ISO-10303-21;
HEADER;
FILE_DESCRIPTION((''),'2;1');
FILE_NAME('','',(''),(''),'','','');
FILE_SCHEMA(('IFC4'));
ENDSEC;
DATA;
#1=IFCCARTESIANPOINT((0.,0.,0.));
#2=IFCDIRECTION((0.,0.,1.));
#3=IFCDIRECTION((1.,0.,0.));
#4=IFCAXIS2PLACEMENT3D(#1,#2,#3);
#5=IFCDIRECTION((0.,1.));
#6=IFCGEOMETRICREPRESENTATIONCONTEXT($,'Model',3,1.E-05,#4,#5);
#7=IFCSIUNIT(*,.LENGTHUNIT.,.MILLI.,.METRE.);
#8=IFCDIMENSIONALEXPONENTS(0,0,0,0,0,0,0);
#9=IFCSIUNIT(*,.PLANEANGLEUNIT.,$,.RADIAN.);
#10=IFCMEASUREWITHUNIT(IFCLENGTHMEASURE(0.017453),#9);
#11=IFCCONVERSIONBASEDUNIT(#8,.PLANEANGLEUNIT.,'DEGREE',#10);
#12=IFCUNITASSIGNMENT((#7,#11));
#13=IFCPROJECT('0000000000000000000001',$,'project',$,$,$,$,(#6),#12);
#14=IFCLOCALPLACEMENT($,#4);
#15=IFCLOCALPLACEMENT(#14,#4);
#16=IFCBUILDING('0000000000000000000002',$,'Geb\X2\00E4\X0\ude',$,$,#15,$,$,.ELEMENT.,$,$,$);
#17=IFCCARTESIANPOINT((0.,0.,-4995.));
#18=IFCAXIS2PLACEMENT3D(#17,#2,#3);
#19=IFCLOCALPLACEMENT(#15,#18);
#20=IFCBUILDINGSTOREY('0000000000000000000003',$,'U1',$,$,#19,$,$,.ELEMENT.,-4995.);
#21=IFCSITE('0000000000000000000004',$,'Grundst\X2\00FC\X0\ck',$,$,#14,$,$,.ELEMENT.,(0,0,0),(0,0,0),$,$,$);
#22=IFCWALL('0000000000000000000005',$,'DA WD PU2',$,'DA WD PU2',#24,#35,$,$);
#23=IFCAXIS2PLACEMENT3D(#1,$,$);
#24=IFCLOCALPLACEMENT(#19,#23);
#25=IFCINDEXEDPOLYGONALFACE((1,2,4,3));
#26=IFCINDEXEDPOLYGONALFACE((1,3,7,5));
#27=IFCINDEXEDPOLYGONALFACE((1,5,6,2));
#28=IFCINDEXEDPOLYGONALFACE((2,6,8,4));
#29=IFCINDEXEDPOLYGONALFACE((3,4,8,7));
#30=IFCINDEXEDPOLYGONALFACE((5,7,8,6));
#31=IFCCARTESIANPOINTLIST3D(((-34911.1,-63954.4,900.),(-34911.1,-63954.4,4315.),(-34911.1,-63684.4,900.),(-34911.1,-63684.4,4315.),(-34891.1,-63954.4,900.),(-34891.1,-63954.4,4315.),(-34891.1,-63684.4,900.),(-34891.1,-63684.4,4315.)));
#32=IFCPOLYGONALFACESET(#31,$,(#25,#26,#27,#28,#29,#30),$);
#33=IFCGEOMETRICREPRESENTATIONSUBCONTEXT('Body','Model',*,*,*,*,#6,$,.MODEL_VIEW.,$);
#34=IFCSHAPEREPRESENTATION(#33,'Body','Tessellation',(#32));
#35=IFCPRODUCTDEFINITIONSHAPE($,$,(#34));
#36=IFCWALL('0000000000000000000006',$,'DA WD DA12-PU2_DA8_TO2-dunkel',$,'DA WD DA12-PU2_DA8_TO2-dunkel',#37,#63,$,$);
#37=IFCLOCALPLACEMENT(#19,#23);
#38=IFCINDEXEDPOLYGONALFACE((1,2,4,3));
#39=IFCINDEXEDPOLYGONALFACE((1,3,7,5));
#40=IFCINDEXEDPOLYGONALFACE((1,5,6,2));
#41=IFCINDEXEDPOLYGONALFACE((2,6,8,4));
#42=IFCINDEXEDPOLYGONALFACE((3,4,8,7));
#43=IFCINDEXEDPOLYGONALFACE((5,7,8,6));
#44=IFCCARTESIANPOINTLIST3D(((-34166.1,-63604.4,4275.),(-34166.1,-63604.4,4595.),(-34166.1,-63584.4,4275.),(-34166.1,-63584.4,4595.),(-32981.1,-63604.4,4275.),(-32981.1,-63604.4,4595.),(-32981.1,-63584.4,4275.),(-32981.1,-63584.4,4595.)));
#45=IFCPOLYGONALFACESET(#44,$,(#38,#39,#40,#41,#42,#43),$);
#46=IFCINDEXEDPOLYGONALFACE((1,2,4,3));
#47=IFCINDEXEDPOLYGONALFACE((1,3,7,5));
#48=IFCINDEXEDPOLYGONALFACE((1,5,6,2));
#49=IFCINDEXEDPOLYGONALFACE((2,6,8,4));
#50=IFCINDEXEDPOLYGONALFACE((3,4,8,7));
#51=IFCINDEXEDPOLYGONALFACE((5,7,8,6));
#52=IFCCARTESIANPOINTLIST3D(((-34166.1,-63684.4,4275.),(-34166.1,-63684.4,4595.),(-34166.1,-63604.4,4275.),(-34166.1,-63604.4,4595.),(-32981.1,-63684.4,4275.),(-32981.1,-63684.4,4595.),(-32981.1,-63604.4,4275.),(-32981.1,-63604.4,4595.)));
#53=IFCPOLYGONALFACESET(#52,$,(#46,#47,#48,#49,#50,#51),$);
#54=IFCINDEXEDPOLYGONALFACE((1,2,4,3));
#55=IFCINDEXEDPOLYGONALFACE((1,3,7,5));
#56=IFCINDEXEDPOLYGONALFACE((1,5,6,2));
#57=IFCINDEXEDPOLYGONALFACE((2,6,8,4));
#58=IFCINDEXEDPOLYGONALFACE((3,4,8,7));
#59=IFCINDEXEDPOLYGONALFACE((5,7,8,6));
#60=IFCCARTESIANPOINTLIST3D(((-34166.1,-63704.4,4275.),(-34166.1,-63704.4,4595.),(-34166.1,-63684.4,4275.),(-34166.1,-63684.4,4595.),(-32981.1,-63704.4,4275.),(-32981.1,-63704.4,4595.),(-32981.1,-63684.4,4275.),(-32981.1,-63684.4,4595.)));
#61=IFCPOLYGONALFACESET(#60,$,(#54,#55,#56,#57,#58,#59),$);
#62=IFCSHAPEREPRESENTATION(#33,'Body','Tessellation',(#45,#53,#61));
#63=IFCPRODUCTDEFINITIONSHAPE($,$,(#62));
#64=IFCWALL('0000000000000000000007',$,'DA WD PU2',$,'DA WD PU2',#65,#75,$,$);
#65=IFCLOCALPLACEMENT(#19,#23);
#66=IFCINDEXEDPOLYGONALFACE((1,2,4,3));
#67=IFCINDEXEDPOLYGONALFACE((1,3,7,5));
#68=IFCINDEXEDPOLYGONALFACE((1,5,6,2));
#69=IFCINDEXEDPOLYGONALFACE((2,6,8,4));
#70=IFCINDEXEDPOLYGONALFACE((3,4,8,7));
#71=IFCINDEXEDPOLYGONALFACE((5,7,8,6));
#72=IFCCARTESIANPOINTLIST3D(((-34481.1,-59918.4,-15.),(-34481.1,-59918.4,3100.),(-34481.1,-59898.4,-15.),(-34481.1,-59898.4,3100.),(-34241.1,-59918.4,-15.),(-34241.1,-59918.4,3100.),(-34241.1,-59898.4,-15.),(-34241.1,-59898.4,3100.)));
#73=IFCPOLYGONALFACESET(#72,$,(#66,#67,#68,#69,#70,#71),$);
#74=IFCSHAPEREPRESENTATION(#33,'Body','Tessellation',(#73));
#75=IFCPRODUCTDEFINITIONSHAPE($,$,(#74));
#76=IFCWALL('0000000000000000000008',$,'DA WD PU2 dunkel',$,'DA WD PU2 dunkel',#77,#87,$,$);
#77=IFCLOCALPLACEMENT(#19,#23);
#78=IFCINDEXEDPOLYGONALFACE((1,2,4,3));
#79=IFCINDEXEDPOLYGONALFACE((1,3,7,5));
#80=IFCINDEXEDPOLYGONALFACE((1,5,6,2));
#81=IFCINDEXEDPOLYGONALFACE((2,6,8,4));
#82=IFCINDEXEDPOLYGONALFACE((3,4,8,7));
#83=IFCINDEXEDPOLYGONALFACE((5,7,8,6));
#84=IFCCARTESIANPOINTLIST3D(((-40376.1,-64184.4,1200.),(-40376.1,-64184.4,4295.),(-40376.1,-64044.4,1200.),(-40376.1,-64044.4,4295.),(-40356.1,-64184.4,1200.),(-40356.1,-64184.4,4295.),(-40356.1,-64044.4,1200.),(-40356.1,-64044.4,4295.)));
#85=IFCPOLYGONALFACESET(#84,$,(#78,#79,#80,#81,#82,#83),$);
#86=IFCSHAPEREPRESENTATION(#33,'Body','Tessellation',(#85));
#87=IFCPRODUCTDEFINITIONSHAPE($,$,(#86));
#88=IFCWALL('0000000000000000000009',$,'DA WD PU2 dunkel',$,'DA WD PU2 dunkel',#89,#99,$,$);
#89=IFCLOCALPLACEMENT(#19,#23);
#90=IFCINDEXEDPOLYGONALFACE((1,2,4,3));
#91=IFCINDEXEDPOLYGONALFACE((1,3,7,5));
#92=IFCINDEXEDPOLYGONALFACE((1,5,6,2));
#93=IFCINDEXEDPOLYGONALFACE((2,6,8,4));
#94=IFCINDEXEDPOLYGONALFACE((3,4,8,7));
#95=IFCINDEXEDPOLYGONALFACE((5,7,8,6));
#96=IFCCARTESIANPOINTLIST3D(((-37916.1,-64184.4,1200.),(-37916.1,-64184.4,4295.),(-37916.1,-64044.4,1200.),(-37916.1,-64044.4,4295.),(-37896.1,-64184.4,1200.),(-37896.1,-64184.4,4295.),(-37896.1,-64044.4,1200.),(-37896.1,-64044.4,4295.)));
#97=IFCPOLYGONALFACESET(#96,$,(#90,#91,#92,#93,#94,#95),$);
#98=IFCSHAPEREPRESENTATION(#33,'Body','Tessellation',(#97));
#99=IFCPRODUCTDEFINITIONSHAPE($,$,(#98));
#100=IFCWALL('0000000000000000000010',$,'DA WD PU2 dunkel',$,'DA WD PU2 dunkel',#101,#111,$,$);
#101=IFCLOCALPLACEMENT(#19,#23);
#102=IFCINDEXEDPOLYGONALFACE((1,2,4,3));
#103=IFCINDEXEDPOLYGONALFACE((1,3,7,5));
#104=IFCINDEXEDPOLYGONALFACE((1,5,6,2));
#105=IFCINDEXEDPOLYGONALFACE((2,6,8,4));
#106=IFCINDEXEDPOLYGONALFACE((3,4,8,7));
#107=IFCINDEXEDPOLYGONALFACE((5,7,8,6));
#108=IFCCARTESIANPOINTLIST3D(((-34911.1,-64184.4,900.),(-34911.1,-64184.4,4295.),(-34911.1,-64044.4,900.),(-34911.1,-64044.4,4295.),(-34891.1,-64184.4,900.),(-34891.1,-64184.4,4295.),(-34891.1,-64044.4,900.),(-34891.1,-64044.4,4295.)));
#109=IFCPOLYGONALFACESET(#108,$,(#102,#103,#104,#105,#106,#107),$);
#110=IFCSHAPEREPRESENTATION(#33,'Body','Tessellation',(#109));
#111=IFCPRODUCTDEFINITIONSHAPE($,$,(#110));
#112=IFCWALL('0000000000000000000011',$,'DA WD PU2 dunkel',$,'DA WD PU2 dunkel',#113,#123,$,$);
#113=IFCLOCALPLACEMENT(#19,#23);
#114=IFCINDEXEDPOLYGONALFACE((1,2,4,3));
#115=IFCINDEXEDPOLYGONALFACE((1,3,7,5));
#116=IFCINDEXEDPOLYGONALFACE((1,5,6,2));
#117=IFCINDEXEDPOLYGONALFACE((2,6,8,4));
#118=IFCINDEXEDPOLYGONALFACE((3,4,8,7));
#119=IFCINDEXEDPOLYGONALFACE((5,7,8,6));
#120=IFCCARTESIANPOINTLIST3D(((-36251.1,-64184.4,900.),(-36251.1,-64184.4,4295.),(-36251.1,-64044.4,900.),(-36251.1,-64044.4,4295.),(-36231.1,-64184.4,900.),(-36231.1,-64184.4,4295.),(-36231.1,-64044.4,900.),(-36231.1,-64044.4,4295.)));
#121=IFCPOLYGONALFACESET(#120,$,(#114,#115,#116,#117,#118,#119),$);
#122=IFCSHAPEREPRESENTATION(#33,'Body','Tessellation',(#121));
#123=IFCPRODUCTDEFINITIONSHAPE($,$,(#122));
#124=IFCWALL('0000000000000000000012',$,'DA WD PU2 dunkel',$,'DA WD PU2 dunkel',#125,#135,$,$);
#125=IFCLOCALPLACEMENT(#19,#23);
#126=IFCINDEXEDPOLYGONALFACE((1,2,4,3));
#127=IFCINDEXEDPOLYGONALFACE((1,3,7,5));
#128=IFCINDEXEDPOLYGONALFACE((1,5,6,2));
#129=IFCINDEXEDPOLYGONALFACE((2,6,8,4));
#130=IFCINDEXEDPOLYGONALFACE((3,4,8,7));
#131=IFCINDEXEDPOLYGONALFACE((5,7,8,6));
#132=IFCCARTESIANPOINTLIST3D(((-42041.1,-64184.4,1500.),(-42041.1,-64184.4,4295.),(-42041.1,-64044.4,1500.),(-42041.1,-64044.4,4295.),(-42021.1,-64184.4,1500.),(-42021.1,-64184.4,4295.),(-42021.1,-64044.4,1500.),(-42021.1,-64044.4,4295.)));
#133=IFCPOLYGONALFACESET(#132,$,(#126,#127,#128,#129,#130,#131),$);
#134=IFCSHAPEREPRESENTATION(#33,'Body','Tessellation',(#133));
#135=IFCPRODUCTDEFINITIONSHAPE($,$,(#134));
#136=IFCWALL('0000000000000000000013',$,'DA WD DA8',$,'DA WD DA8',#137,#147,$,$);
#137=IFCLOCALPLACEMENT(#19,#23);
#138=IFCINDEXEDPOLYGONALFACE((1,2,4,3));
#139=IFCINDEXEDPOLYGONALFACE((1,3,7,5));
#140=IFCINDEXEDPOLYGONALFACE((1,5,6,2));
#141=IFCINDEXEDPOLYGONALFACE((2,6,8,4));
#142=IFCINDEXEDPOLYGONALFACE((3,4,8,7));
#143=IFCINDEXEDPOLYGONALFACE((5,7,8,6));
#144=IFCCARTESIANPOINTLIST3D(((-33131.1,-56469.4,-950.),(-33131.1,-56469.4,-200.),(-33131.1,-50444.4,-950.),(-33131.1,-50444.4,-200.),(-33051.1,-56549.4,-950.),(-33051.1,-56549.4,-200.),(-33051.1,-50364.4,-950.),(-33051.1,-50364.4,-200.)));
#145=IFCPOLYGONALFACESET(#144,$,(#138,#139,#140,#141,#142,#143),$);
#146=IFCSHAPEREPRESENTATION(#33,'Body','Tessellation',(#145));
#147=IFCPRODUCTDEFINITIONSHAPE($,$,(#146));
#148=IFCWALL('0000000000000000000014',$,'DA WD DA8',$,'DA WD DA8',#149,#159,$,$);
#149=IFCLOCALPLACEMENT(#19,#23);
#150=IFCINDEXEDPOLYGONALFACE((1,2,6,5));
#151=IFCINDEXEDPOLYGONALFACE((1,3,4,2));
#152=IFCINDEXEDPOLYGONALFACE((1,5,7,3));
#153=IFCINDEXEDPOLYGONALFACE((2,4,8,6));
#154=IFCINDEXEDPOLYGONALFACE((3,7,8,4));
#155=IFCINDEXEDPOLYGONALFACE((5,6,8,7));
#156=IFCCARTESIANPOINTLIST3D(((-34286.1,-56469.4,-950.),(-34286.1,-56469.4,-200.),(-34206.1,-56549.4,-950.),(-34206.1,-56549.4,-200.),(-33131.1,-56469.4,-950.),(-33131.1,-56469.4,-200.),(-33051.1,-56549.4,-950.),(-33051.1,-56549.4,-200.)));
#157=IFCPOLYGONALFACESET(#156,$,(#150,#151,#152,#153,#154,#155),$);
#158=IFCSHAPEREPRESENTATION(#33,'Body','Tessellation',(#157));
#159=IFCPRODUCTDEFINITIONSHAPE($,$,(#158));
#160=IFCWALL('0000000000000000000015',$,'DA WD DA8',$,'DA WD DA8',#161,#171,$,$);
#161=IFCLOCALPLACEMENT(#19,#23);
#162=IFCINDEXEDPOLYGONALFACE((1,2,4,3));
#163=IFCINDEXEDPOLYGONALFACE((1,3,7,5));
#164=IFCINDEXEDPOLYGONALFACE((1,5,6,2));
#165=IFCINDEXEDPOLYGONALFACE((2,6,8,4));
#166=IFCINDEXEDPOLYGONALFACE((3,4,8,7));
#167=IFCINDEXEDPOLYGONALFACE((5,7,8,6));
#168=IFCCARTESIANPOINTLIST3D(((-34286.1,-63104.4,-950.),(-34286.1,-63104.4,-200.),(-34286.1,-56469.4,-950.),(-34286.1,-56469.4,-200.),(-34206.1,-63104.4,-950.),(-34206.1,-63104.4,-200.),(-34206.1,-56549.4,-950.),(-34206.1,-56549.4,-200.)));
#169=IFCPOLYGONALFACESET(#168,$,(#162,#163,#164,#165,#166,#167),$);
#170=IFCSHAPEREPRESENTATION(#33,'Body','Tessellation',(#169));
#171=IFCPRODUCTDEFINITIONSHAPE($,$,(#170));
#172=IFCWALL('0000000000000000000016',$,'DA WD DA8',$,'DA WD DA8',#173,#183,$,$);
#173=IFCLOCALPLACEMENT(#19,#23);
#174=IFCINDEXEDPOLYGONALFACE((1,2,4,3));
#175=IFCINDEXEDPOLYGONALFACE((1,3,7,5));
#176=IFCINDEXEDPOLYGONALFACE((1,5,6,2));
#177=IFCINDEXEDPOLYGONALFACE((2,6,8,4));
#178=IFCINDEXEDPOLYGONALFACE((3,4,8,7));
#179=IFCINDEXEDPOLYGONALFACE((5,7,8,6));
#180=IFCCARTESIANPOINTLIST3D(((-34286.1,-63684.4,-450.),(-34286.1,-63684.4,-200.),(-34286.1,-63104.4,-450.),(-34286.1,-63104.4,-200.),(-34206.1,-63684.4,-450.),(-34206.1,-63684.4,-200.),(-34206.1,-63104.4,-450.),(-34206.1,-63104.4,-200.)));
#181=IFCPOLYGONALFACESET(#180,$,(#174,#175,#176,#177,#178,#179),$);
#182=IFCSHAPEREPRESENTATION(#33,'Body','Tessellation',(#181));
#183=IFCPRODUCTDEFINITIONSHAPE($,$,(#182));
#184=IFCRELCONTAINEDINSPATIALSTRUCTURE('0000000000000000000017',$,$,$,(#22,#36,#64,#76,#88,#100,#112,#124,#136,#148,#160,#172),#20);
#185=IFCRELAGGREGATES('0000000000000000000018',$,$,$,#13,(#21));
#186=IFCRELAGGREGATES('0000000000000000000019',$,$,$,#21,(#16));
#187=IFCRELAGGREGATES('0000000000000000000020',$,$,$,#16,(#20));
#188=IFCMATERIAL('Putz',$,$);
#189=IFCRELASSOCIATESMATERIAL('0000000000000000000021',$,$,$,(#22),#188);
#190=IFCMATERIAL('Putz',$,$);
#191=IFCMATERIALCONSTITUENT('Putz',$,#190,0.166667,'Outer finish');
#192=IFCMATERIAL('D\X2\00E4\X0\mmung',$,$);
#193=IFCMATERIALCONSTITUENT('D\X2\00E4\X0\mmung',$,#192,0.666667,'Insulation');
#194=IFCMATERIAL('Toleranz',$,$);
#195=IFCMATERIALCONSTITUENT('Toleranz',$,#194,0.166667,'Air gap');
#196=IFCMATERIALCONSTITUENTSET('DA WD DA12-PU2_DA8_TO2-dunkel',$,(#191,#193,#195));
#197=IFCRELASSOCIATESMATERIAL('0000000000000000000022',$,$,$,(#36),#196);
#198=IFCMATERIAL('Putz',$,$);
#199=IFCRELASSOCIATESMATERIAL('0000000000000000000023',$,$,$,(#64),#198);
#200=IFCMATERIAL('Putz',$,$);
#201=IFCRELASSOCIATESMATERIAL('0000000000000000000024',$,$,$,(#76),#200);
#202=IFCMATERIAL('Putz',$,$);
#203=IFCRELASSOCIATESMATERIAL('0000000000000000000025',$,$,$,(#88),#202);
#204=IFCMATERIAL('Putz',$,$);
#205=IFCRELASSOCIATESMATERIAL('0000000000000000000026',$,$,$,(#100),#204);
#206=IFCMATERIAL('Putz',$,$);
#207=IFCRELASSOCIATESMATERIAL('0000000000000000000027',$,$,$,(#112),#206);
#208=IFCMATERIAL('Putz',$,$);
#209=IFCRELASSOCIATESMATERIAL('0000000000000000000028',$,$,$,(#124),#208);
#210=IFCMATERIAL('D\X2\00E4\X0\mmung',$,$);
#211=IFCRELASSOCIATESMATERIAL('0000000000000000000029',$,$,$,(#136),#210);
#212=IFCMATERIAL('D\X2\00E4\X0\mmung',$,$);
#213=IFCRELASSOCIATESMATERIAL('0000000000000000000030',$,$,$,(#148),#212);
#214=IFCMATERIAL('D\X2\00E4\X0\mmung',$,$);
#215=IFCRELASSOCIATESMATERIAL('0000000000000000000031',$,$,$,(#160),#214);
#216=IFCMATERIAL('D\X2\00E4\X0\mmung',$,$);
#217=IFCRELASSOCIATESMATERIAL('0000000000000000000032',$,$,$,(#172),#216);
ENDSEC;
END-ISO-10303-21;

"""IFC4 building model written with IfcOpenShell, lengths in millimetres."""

from ifc_helpers import new_model, entity, si_unit, converted_unit, direction, frame, origin_with_axes, place, context, subcontext, project, spatial, line, indexed_curve, outline, extrude, material, constituent, constituent_set, element, save


model = new_model("IFC4")

# Units and contexts
model_context = context("Model", 3, precision=1e-05, world=origin_with_axes(), true_north=direction((0.0, 1.0)))
body_context = subcontext(model_context, "Body", "Model", "MODEL_VIEW")
ifc_project = project(units=[si_unit("LENGTHUNIT", "METRE", prefix="MILLI"), converted_unit("PLANEANGLEUNIT", "DEGREE", entity("IfcLengthMeasure", 0.017453), si_unit("PLANEANGLEUNIT", "RADIAN"), dimensions=[0, 0, 0, 0, 0, 0, 0])], contexts=[model_context])

# Site, building, storey
site_placement = place(None, origin_with_axes())
site = spatial("IfcSite", under=ifc_project, at=site_placement, Name="Grundstück", CompositionType="ELEMENT", RefLatitude=(0, 0, 0), RefLongitude=(0, 0, 0))
building_placement = place(site_placement, origin_with_axes())
building = spatial("IfcBuilding", under=site, at=building_placement, Name="Gebäude", CompositionType="ELEMENT")
storey_placement = place(building_placement, frame((0.0, 0.0, -4995.0), z_axis=(0.0, 0.0, 1.0), x_axis=(1.0, 0.0, 0.0)))
storey = spatial("IfcBuildingStorey", under=building, at=storey_placement, Name="U1", CompositionType="ELEMENT", Elevation=-4995.0)

# Walls
ifc_material_1 = material(Name="Putz")
wall_1_placement = place(storey_placement, frame((-34901.1, -63954.4, 900.0), z_axis=(0.0, 0.0, 1.0), x_axis=(0.0, 1.0, 0.0)))
element("IfcWall", 1, at=wall_1_placement, inside=storey, material=ifc_material_1, Name="DA WD PU2", ObjectType="DA WD PU2", context=body_context, shape_type="SweptSolid", body=[
    extrude(outline(indexed_curve([(0.0, -10.0), (0.0, 10.0), (270.0, 10.0), (270.0, -10.0)], segments=[line(1, 2), line(2, 3), line(3, 4), line(4, 1)])), origin_with_axes(), (0.0, 0.0, 1.0), 3415.0),
])
ifc_material_2 = material(Name="Putz")
ifc_constituent_1 = constituent(ifc_material_2, Name="Putz", Category="Outer finish", fraction=0.166667)
ifc_material_3 = material(Name="Dämmung")
ifc_constituent_2 = constituent(ifc_material_3, Name="Dämmung", Category="Insulation", fraction=0.666667)
ifc_material_4 = material(Name="Toleranz")
ifc_constituent_3 = constituent(ifc_material_4, Name="Toleranz", Category="Air gap", fraction=0.166667)
ifc_constituent_set_1 = constituent_set(constituents=[ifc_constituent_1, ifc_constituent_2, ifc_constituent_3], Name="DA WD DA12-PU2_DA8_TO2-dunkel")
wall_2_placement = place(storey_placement, frame((-34166.1, -63644.4, 4275.0), z_axis=(0.0, 0.0, 1.0), x_axis=(1.0, 0.0, 0.0)))
element("IfcWall", 2, at=wall_2_placement, inside=storey, material=ifc_constituent_set_1, Name="DA WD DA12-PU2_DA8_TO2-dunkel", ObjectType="DA WD DA12-PU2_DA8_TO2-dunkel", context=body_context, shape_type="SweptSolid", body=[
    extrude(outline(indexed_curve([(1185.0, 60.0), (1185.0, 40.0), (0.0, 40.0), (0.0, 60.0)], segments=[line(1, 2), line(2, 3), line(3, 4), line(4, 1)])), origin_with_axes(), (0.0, 0.0, 1.0), 320.0),
    extrude(outline(indexed_curve([(1185.0, 40.0), (1185.0, -40.0), (0.0, -40.0), (0.0, 40.0)], segments=[line(1, 2), line(2, 3), line(3, 4), line(4, 1)])), origin_with_axes(), (0.0, 0.0, 1.0), 320.0),
    extrude(outline(indexed_curve([(1185.0, -40.0), (1185.0, -60.0), (0.0, -60.0), (0.0, -40.0)], segments=[line(1, 2), line(2, 3), line(3, 4), line(4, 1)])), origin_with_axes(), (0.0, 0.0, 1.0), 320.0),
])
ifc_material_5 = material(Name="Putz")
wall_3_placement = place(storey_placement, frame((-34241.1, -59908.4, -15.0), z_axis=(0.0, 0.0, 1.0), x_axis=(-1.0, 0.0, 0.0)))
element("IfcWall", 3, at=wall_3_placement, inside=storey, material=ifc_material_5, Name="DA WD PU2", ObjectType="DA WD PU2", context=body_context, shape_type="SweptSolid", body=[
    extrude(outline(indexed_curve([(0.0, -10.0), (0.0, 10.0), (240.0, 10.0), (240.0, -10.0)], segments=[line(1, 2), line(2, 3), line(3, 4), line(4, 1)])), origin_with_axes(), (0.0, 0.0, 1.0), 3115.0),
])
ifc_material_6 = material(Name="Putz")
wall_4_placement = place(storey_placement, frame((-40366.1, -64184.4, 1200.0), z_axis=(0.0, 0.0, 1.0), x_axis=(0.0, 1.0, 0.0)))
element("IfcWall", 4, at=wall_4_placement, inside=storey, material=ifc_material_6, Name="DA WD PU2 dunkel", ObjectType="DA WD PU2 dunkel", context=body_context, shape_type="SweptSolid", body=[
    extrude(outline(indexed_curve([(0.0, -10.0), (0.0, 10.0), (140.0, 10.0), (140.0, -10.0)], segments=[line(1, 2), line(2, 3), line(3, 4), line(4, 1)])), origin_with_axes(), (0.0, 0.0, 1.0), 3095.0),
])
ifc_material_7 = material(Name="Putz")
wall_5_placement = place(storey_placement, frame((-37906.1, -64184.4, 1200.0), z_axis=(0.0, 0.0, 1.0), x_axis=(0.0, 1.0, 0.0)))
element("IfcWall", 5, at=wall_5_placement, inside=storey, material=ifc_material_7, Name="DA WD PU2 dunkel", ObjectType="DA WD PU2 dunkel", context=body_context, shape_type="SweptSolid", body=[
    extrude(outline(indexed_curve([(0.0, -10.0), (0.0, 10.0), (140.0, 10.0), (140.0, -10.0)], segments=[line(1, 2), line(2, 3), line(3, 4), line(4, 1)])), origin_with_axes(), (0.0, 0.0, 1.0), 3095.0),
])
ifc_material_8 = material(Name="Putz")
wall_6_placement = place(storey_placement, frame((-34901.1, -64184.4, 900.0), z_axis=(0.0, 0.0, 1.0), x_axis=(0.0, 1.0, 0.0)))
element("IfcWall", 6, at=wall_6_placement, inside=storey, material=ifc_material_8, Name="DA WD PU2 dunkel", ObjectType="DA WD PU2 dunkel", context=body_context, shape_type="SweptSolid", body=[
    extrude(outline(indexed_curve([(0.0, -10.0), (0.0, 10.0), (140.0, 10.0), (140.0, -10.0)], segments=[line(1, 2), line(2, 3), line(3, 4), line(4, 1)])), origin_with_axes(), (0.0, 0.0, 1.0), 3395.0),
])
ifc_material_9 = material(Name="Putz")
wall_7_placement = place(storey_placement, frame((-36241.1, -64184.4, 900.0), z_axis=(0.0, 0.0, 1.0), x_axis=(0.0, 1.0, 0.0)))
element("IfcWall", 7, at=wall_7_placement, inside=storey, material=ifc_material_9, Name="DA WD PU2 dunkel", ObjectType="DA WD PU2 dunkel", context=body_context, shape_type="SweptSolid", body=[
    extrude(outline(indexed_curve([(0.0, -10.0), (0.0, 10.0), (140.0, 10.0), (140.0, -10.0)], segments=[line(1, 2), line(2, 3), line(3, 4), line(4, 1)])), origin_with_axes(), (0.0, 0.0, 1.0), 3395.0),
])
ifc_material_10 = material(Name="Putz")
wall_8_placement = place(storey_placement, frame((-42031.1, -64184.4, 1500.0), z_axis=(0.0, 0.0, 1.0), x_axis=(0.0, 1.0, 0.0)))
element("IfcWall", 8, at=wall_8_placement, inside=storey, material=ifc_material_10, Name="DA WD PU2 dunkel", ObjectType="DA WD PU2 dunkel", context=body_context, shape_type="SweptSolid", body=[
    extrude(outline(indexed_curve([(0.0, -10.0), (0.0, 10.0), (140.0, 10.0), (140.0, -10.0)], segments=[line(1, 2), line(2, 3), line(3, 4), line(4, 1)])), origin_with_axes(), (0.0, 0.0, 1.0), 2795.0),
])
ifc_material_11 = material(Name="Dämmung")
wall_9_placement = place(storey_placement, frame((-33091.1, -50404.4, -950.0), z_axis=(0.0, 0.0, 1.0), x_axis=(0.0, -1.0, 0.0)))
element("IfcWall", 9, at=wall_9_placement, inside=storey, material=ifc_material_11, Name="DA WD DA8", ObjectType="DA WD DA8", context=body_context, shape_type="SweptSolid", body=[
    extrude(outline(indexed_curve([(40.0, -40.0), (-40.0, 40.0), (6145.0, 40.0), (6065.0, -40.0)], segments=[line(1, 2), line(2, 3), line(3, 4), line(4, 1)])), origin_with_axes(), (0.0, 0.0, 1.0), 750.0),
])
ifc_material_12 = material(Name="Dämmung")
wall_10_placement = place(storey_placement, frame((-33091.1, -56509.4, -950.0), z_axis=(0.0, 0.0, 1.0), x_axis=(-1.0, 0.0, 0.0)))
element("IfcWall", 10, at=wall_10_placement, inside=storey, material=ifc_material_12, Name="DA WD DA8", ObjectType="DA WD DA8", context=body_context, shape_type="SweptSolid", body=[
    extrude(outline(indexed_curve([(40.0, -40.0), (-40.0, 40.0), (1115.0, 40.0), (1195.0, -40.0)], segments=[line(1, 2), line(2, 3), line(3, 4), line(4, 1)])), origin_with_axes(), (0.0, 0.0, 1.0), 750.0),
])
ifc_material_13 = material(Name="Dämmung")
wall_11_placement = place(storey_placement, frame((-34246.1, -56509.4, -950.0), z_axis=(0.0, 0.0, 1.0), x_axis=(0.0, -1.0, 0.0)))
element("IfcWall", 11, at=wall_11_placement, inside=storey, material=ifc_material_13, Name="DA WD DA8", ObjectType="DA WD DA8", context=body_context, shape_type="SweptSolid", body=[
    extrude(outline(indexed_curve([(-40.0, -40.0), (40.0, 40.0), (6595.0, 40.0), (6595.0, -40.0)], segments=[line(1, 2), line(2, 3), line(3, 4), line(4, 1)])), origin_with_axes(), (0.0, 0.0, 1.0), 750.0),
])
ifc_material_14 = material(Name="Dämmung")
wall_12_placement = place(storey_placement, frame((-34246.1, -63104.4, -450.0), z_axis=(0.0, 0.0, 1.0), x_axis=(0.0, -1.0, 0.0)))
element("IfcWall", 12, at=wall_12_placement, inside=storey, material=ifc_material_14, Name="DA WD DA8", ObjectType="DA WD DA8", context=body_context, shape_type="SweptSolid", body=[
    extrude(outline(indexed_curve([(0.0, -40.0), (0.0, 40.0), (580.0, 40.0), (580.0, -40.0)], segments=[line(1, 2), line(2, 3), line(3, 4), line(4, 1)])), origin_with_axes(), (0.0, 0.0, 1.0), 250.0),
])

save(model, "model.ifc")
